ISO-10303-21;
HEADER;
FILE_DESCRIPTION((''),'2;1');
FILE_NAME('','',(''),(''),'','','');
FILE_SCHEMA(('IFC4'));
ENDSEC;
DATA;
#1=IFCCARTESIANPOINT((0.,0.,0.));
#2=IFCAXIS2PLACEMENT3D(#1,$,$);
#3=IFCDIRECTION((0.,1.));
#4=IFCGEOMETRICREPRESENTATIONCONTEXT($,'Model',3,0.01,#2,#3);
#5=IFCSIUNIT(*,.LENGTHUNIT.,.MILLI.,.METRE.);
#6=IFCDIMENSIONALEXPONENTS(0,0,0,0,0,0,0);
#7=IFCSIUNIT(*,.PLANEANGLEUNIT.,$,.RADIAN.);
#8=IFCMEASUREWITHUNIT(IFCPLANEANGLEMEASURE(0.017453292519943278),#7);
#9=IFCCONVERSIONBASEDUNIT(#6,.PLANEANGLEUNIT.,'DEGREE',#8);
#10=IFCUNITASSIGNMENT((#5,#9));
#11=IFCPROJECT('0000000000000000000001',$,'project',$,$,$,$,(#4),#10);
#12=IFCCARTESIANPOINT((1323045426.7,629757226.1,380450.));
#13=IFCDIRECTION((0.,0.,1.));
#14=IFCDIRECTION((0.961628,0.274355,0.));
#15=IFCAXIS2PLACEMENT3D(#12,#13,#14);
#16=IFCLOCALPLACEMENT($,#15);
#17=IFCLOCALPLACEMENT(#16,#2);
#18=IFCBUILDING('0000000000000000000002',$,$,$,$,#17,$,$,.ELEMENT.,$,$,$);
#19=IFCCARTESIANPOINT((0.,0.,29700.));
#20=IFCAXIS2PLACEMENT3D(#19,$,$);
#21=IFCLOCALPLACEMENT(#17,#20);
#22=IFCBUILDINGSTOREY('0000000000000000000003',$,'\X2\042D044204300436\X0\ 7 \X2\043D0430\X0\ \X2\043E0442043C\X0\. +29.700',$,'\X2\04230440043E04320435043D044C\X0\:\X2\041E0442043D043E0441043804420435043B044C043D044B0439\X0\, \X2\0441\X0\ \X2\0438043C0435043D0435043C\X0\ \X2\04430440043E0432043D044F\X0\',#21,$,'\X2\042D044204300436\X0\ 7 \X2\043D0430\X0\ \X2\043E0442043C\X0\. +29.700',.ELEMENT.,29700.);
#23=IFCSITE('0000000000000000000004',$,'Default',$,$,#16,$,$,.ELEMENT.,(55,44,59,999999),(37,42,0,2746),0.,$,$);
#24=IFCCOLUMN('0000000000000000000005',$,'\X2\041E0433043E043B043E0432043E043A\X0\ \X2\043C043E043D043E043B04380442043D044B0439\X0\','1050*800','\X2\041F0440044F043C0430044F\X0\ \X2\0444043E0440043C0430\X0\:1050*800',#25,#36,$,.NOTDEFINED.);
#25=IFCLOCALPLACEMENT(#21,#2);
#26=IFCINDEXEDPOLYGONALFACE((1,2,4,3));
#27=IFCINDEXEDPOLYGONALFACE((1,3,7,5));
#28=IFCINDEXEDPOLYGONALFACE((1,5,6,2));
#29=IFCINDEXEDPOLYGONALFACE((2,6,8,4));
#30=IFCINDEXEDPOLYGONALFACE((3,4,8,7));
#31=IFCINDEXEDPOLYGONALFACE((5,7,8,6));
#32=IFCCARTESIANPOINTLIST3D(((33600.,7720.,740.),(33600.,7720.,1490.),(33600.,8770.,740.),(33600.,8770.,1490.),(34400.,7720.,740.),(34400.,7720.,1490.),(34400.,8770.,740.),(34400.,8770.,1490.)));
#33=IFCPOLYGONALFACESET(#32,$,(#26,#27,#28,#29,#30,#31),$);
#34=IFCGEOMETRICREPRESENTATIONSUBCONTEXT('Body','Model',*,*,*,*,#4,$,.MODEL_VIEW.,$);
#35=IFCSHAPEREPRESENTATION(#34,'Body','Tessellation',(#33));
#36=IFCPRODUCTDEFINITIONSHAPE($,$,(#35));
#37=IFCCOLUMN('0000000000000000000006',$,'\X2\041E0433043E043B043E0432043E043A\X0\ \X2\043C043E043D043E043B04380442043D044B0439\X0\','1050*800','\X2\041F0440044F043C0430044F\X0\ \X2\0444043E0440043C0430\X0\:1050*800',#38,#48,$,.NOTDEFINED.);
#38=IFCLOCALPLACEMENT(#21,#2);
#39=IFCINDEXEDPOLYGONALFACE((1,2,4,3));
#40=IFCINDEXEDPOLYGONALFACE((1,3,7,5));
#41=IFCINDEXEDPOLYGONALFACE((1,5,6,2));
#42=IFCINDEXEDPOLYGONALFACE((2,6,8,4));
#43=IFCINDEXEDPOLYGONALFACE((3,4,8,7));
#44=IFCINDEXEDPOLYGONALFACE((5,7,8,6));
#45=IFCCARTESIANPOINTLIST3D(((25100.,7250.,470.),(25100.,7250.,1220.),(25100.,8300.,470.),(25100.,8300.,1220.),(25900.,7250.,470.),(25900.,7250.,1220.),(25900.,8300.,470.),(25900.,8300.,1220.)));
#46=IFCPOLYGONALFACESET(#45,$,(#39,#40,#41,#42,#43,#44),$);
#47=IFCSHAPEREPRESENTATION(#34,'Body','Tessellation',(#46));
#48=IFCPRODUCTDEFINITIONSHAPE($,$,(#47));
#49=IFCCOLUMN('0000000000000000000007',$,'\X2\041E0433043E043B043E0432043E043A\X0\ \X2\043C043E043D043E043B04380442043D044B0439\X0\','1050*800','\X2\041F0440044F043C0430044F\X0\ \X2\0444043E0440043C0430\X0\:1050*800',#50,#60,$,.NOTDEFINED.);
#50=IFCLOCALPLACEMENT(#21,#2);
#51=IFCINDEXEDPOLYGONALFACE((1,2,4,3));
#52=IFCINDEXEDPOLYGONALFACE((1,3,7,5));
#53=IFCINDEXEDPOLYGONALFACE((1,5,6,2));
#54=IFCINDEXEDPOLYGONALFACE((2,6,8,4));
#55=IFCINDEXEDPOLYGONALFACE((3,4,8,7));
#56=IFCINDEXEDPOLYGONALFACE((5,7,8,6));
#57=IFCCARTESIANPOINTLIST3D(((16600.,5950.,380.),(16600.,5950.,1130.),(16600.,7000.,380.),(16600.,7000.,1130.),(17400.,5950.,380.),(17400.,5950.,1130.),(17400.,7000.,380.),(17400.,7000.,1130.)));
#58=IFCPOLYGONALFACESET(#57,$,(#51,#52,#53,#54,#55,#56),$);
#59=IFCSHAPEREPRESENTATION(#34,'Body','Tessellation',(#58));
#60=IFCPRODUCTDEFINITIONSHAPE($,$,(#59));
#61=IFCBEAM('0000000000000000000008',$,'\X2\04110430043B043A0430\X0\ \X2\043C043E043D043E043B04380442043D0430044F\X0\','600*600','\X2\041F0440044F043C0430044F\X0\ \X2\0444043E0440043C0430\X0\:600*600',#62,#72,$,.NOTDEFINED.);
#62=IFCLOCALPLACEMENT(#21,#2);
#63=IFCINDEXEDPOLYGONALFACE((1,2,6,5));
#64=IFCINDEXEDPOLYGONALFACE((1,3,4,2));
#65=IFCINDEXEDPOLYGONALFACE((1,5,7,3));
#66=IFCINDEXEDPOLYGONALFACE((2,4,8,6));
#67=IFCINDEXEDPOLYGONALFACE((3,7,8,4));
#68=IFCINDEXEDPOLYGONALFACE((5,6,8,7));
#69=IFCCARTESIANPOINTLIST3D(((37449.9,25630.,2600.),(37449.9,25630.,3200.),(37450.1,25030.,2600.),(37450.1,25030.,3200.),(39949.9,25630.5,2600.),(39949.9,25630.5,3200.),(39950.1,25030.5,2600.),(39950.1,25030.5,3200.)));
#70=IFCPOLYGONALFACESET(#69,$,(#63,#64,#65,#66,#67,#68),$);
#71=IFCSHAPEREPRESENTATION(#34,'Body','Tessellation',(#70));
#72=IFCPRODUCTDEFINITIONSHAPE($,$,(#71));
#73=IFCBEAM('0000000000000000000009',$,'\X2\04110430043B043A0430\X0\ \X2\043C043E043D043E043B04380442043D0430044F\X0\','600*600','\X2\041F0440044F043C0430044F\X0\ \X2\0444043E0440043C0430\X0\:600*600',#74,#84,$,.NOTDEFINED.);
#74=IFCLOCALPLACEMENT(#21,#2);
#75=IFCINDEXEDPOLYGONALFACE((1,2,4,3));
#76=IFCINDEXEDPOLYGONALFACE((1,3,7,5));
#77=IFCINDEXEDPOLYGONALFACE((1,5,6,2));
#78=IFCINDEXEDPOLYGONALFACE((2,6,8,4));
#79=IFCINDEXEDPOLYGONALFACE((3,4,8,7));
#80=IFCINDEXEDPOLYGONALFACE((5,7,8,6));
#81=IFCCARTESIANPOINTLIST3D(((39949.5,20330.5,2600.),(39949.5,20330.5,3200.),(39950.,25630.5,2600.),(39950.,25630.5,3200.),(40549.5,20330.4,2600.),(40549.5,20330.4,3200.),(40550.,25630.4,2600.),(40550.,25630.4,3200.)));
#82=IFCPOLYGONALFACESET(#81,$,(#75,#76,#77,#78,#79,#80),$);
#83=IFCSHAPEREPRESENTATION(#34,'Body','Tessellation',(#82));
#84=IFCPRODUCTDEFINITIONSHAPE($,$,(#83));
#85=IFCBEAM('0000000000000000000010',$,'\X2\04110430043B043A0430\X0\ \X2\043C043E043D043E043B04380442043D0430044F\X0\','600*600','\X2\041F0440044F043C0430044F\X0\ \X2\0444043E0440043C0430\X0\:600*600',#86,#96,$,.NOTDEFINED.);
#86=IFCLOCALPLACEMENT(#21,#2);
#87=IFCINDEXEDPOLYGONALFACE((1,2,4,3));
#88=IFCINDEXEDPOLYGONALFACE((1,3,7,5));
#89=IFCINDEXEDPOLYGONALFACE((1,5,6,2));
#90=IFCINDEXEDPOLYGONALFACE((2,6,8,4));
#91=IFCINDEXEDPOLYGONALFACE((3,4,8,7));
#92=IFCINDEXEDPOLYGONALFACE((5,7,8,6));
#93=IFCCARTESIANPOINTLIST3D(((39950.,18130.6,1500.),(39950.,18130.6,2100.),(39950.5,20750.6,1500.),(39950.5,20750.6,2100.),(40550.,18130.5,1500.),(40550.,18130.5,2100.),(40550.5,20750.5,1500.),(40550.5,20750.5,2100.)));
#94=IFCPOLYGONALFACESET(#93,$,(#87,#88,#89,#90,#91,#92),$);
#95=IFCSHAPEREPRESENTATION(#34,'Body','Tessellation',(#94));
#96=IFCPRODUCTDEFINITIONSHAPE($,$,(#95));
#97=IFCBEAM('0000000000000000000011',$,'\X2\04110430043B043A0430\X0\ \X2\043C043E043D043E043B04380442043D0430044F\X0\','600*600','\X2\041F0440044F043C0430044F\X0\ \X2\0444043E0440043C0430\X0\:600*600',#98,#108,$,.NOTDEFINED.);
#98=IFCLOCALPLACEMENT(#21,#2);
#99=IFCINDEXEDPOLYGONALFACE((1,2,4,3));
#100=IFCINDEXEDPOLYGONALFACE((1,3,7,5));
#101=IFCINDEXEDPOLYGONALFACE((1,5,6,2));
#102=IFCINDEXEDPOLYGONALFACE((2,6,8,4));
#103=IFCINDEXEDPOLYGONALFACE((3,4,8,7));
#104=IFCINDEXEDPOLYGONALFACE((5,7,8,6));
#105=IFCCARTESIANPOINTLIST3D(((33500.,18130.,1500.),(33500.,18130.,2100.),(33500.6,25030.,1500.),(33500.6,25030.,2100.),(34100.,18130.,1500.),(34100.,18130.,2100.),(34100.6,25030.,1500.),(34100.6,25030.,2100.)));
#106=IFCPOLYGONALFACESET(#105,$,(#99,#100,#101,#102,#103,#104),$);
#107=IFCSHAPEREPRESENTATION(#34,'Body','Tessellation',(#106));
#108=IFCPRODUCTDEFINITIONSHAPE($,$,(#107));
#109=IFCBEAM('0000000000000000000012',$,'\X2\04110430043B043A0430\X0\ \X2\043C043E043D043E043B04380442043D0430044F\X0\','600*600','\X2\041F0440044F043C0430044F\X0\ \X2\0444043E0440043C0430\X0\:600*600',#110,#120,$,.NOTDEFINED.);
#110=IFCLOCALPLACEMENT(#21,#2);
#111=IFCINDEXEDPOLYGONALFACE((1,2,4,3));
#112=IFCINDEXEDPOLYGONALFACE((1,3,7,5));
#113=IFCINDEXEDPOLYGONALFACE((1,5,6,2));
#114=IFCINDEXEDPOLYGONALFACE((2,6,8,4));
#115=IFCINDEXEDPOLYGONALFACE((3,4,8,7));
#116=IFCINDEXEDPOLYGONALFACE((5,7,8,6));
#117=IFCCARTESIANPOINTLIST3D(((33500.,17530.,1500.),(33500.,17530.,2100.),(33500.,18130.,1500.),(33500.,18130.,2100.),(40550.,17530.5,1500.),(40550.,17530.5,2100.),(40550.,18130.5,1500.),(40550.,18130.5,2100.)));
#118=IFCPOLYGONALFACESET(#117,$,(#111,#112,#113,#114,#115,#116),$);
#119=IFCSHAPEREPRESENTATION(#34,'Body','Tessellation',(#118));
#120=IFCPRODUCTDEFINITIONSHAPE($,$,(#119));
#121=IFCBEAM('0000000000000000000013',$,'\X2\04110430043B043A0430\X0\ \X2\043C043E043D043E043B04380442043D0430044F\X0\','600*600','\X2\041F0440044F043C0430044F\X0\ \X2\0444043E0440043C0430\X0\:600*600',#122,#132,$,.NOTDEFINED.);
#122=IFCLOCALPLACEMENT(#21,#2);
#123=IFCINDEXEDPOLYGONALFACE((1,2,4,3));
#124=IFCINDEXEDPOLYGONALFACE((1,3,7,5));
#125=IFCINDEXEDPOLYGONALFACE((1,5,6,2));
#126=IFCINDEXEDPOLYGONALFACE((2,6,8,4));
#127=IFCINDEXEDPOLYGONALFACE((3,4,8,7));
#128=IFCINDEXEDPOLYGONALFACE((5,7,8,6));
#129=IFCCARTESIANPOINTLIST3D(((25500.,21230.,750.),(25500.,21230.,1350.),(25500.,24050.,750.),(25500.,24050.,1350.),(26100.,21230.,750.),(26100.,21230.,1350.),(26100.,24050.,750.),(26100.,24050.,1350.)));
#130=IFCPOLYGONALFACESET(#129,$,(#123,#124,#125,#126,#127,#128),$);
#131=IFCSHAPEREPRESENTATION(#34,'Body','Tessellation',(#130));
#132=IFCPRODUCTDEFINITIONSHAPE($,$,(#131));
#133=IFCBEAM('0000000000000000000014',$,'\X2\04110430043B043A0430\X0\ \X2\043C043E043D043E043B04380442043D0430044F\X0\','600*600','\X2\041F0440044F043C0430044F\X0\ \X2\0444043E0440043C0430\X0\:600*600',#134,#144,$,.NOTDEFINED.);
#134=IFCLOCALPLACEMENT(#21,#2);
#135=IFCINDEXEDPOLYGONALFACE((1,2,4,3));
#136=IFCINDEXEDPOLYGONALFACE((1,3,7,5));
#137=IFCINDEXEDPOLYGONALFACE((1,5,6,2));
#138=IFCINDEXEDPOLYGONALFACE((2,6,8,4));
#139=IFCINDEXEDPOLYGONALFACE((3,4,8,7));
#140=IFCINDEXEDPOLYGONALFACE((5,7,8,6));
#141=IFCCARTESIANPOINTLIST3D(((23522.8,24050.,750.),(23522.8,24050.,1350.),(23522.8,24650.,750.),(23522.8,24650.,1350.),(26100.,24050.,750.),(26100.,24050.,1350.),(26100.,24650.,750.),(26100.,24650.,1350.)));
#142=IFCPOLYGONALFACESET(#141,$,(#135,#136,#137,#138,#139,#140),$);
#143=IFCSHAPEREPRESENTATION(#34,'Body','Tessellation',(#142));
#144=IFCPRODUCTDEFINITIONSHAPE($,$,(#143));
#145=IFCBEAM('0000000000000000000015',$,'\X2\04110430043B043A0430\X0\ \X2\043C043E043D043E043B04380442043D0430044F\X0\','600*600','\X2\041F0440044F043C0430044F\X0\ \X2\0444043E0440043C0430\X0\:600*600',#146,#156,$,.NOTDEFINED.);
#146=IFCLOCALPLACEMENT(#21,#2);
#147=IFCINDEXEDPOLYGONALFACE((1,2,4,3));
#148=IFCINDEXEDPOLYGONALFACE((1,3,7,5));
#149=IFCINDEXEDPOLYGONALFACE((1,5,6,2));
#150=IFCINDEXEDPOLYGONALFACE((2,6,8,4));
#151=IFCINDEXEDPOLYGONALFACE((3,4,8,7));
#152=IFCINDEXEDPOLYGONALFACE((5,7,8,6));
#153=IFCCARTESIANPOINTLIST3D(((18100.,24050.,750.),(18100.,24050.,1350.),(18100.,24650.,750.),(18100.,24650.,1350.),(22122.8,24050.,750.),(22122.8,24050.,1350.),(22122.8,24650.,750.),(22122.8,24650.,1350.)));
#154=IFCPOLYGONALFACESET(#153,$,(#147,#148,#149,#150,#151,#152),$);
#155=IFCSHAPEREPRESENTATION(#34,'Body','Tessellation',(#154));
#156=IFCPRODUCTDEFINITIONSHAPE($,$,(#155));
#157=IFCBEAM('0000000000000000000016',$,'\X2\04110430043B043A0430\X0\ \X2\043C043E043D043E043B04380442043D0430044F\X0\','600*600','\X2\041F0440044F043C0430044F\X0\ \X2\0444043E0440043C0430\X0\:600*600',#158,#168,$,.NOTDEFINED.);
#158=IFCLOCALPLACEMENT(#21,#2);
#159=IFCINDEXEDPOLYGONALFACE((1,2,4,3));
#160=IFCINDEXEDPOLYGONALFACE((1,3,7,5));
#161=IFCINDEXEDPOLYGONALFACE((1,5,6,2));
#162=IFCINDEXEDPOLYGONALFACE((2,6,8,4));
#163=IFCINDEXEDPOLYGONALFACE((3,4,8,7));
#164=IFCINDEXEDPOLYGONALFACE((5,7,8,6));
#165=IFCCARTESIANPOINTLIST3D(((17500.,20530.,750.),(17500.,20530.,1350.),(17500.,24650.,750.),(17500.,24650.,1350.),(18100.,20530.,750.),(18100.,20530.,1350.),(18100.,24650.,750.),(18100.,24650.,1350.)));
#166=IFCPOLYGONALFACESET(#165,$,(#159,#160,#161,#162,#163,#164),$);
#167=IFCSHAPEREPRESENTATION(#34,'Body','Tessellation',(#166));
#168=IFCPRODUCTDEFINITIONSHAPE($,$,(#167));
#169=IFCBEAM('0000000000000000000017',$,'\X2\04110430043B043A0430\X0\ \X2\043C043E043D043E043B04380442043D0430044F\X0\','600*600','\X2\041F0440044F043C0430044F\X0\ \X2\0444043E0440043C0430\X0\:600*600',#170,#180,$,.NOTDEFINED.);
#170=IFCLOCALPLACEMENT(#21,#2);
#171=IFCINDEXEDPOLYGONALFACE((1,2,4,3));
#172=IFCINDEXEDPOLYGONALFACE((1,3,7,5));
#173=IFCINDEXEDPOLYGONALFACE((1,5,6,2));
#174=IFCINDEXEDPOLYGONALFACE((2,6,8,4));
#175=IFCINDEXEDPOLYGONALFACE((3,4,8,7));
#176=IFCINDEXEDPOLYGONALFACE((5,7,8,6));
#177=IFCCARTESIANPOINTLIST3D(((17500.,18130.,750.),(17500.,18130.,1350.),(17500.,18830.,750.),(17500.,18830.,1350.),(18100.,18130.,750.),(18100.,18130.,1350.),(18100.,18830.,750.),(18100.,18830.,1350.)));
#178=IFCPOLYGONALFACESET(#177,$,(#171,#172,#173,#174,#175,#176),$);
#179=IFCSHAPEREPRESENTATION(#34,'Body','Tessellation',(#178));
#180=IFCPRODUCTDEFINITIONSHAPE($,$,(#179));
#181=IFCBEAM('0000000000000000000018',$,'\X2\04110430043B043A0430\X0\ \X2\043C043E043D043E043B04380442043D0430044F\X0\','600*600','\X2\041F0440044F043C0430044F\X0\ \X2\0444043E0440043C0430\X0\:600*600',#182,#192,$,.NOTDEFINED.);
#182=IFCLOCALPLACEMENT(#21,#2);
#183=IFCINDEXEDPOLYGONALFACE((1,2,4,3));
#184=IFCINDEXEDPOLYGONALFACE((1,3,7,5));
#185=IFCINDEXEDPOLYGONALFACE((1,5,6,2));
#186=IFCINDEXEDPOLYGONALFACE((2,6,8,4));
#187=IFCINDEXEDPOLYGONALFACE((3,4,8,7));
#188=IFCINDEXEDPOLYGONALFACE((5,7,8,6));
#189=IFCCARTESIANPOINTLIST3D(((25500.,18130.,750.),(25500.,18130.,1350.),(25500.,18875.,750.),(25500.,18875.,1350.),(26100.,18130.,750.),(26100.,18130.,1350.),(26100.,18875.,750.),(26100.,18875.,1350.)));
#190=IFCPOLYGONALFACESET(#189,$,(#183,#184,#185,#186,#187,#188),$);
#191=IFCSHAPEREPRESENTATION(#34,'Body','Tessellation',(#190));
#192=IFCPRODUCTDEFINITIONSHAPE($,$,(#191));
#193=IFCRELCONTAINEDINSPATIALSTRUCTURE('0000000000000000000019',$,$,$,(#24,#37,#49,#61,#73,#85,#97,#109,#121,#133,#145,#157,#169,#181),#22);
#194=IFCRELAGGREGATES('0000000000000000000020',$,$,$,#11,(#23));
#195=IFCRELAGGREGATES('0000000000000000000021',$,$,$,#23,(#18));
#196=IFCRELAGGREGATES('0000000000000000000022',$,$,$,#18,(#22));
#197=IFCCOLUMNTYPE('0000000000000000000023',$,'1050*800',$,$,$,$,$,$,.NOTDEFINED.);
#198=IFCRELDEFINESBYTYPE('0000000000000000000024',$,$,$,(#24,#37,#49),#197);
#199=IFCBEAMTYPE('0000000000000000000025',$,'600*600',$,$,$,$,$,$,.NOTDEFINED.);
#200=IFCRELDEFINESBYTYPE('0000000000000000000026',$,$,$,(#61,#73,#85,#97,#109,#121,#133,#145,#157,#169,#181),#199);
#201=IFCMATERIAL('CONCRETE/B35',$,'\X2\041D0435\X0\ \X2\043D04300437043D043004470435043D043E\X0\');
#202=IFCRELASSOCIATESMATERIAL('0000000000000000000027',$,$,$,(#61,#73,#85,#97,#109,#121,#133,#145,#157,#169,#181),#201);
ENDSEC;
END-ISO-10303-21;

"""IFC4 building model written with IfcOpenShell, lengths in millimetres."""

from ifc_helpers import new_model, entity, si_unit, converted_unit, direction, frame, origin, place, context, subcontext, project, spatial, indexed_curve, outline, extrude, material, type_object, element, save


model = new_model("IFC4")

# Units and contexts
model_context = context("Model", 3, precision=0.01, world=origin(), true_north=direction((0.0, 1.0)))
body_context = subcontext(model_context, "Body", "Model", "MODEL_VIEW")
ifc_project = project(units=[si_unit("LENGTHUNIT", "METRE", prefix="MILLI"), converted_unit("PLANEANGLEUNIT", "DEGREE", entity("IfcPlaneAngleMeasure", 0.017453292519943278), si_unit("PLANEANGLEUNIT", "RADIAN"), dimensions=[0, 0, 0, 0, 0, 0, 0])], contexts=[model_context])

# Site, building, storey
site_placement = place(None, frame((1323045426.7, 629757226.1, 380450.0), z_axis=(0.0, 0.0, 1.0), x_axis=(0.961628, 0.274355, 0.0)))
site = spatial("IfcSite", under=ifc_project, at=site_placement, Name="Default", CompositionType="ELEMENT", RefLatitude=(55, 44, 59, 999999), RefLongitude=(37, 42, 0, 2746), RefElevation=0.0)
building_placement = place(site_placement, origin())
building = spatial("IfcBuilding", under=site, at=building_placement, CompositionType="ELEMENT")
storey_placement = place(building_placement, frame((0.0, 0.0, 29700.0)))
storey = spatial("IfcBuildingStorey", under=building, at=storey_placement, Name="Этаж 7 на отм. +29.700", ObjectType="Уровень:Относительный, с именем уровня", LongName="Этаж 7 на отм. +29.700", CompositionType="ELEMENT", Elevation=29700.0)

# Columns
column_type_1 = type_object("IfcColumnType", Name="1050*800", PredefinedType="NOTDEFINED")
column_1_placement = place(storey_placement, origin())
element("IfcColumn", 1, at=column_1_placement, inside=storey, type_object=column_type_1, Name="Оголовок монолитный", Description="1050*800", ObjectType="Прямая форма:1050*800", PredefinedType="NOTDEFINED", context=body_context, shape_type="SweptSolid", body=[
    extrude(outline(indexed_curve([(-525.0, -400.0), (525.0, -400.0), (525.0, 400.0), (-525.0, 400.0), (-525.0, -400.0)], self_intersect=False)), frame((34000.0, 8245.0, 740.0), z_axis=(0.0, 0.0, 1.0), x_axis=(0.0, 1.0, 0.0)), (0.0, 0.0, 1.0), 750.0),
])
column_2_placement = place(storey_placement, origin())
element("IfcColumn", 2, at=column_2_placement, inside=storey, type_object=column_type_1, Name="Оголовок монолитный", Description="1050*800", ObjectType="Прямая форма:1050*800", PredefinedType="NOTDEFINED", context=body_context, shape_type="SweptSolid", body=[
    extrude(outline(indexed_curve([(-525.0, -400.0), (525.0, -400.0), (525.0, 400.0), (-525.0, 400.0), (-525.0, -400.0)], self_intersect=False)), frame((25500.0, 7775.0, 470.0), z_axis=(0.0, 0.0, 1.0), x_axis=(0.0, 1.0, 0.0)), (0.0, 0.0, 1.0), 750.0),
])
column_3_placement = place(storey_placement, origin())
element("IfcColumn", 3, at=column_3_placement, inside=storey, type_object=column_type_1, Name="Оголовок монолитный", Description="1050*800", ObjectType="Прямая форма:1050*800", PredefinedType="NOTDEFINED", context=body_context, shape_type="SweptSolid", body=[
    extrude(outline(indexed_curve([(-525.0, -400.0), (525.0, -400.0), (525.0, 400.0), (-525.0, 400.0), (-525.0, -400.0)], self_intersect=False)), frame((17000.0, 6475.0, 380.0), z_axis=(0.0, 0.0, 1.0), x_axis=(0.0, 1.0, 0.0)), (0.0, 0.0, 1.0), 750.0),
])

# Beams
ifc_material_1 = material(Name="CONCRETE/B35", Category="Не назначено")
beam_type_1 = type_object("IfcBeamType", Name="600*600", PredefinedType="NOTDEFINED")
beam_1_placement = place(storey_placement, origin())
element("IfcBeam", 4, at=beam_1_placement, inside=storey, type_object=beam_type_1, material=ifc_material_1, Name="Балка монолитная", Description="600*600", ObjectType="Прямая форма:600*600", PredefinedType="NOTDEFINED", context=body_context, shape_type="SweptSolid", body=[
    extrude(outline(indexed_curve([(-300.0, -300.0), (300.0, -300.0), (300.0, 300.0), (-300.0, 300.0), (-300.0, -300.0)], self_intersect=False)), frame((37450.0, 25330.0, 2900.0), z_axis=(1.0, 0.00022, 0.0), x_axis=(-0.00022, 1.0, 0.0)), (0.0, 0.0, 1.0), 2500.0),
])
beam_2_placement = place(storey_placement, origin())
element("IfcBeam", 5, at=beam_2_placement, inside=storey, type_object=beam_type_1, material=ifc_material_1, Name="Балка монолитная", Description="600*600", ObjectType="Прямая форма:600*600", PredefinedType="NOTDEFINED", context=body_context, shape_type="SweptSolid", body=[
    extrude(outline(indexed_curve([(-2650.0, -300.0), (2650.0, -300.0), (2650.0, 300.0), (-2650.0, 300.0), (-2650.0, -300.0)], self_intersect=False)), frame((39949.7, 22980.5, 2900.0), z_axis=(1.0, -0.000102, 0.0), x_axis=(-0.000102, -1.0, 0.0)), (0.0, 0.0, 1.0), 600.0),
])
beam_3_placement = place(storey_placement, origin())
element("IfcBeam", 6, at=beam_3_placement, inside=storey, type_object=beam_type_1, material=ifc_material_1, Name="Балка монолитная", Description="600*600", ObjectType="Прямая форма:600*600", PredefinedType="NOTDEFINED", context=body_context, shape_type="SweptSolid", body=[
    extrude(outline(indexed_curve([(-1310.0, -300.0), (1310.0, -300.0), (1310.0, 300.0), (-1310.0, 300.0), (-1310.0, -300.0)], self_intersect=False)), frame((39950.2, 19440.6, 1800.0), z_axis=(1.0, -0.000207, 0.0), x_axis=(-0.000207, -1.0, 0.0)), (0.0, 0.0, 1.0), 600.0),
])
beam_4_placement = place(storey_placement, origin())
element("IfcBeam", 7, at=beam_4_placement, inside=storey, type_object=beam_type_1, material=ifc_material_1, Name="Балка монолитная", Description="600*600", ObjectType="Прямая форма:600*600", PredefinedType="NOTDEFINED", context=body_context, shape_type="SweptSolid", body=[
    extrude(outline(indexed_curve([(-3450.0, -300.0), (3450.0, -300.0), (3450.0, 300.0), (-3450.0, 300.0), (-3450.0, -300.0)], self_intersect=False)), frame((33500.3, 21580.0, 1800.0), z_axis=(1.0, -0.000078, 0.0), x_axis=(-0.000078, -1.0, 0.0)), (0.0, 0.0, 1.0), 600.0),
])
beam_5_placement = place(storey_placement, origin())
element("IfcBeam", 8, at=beam_5_placement, inside=storey, type_object=beam_type_1, material=ifc_material_1, Name="Балка монолитная", Description="600*600", ObjectType="Прямая форма:600*600", PredefinedType="NOTDEFINED", context=body_context, shape_type="SweptSolid", body=[
    extrude(outline(indexed_curve([(-300.0, -300.0), (300.0, -300.0), (300.0, 300.0), (-300.0, 300.0), (-300.0, -300.0)], self_intersect=False)), frame((33500.0, 17830.0, 1800.0), z_axis=(1.0, 0.000077, 0.0), x_axis=(-0.000077, 1.0, 0.0)), (0.0, 0.0, 1.0), 7050.0),
])
beam_6_placement = place(storey_placement, origin())
element("IfcBeam", 9, at=beam_6_placement, inside=storey, type_object=beam_type_1, material=ifc_material_1, Name="Балка монолитная", Description="600*600", ObjectType="Прямая форма:600*600", PredefinedType="NOTDEFINED", context=body_context, shape_type="SweptSolid", body=[
    extrude(outline(indexed_curve([(-1410.0, -300.0), (1410.0, -300.0), (1410.0, 300.0), (-1410.0, 300.0), (-1410.0, -300.0)], self_intersect=False)), frame((25500.0, 22640.0, 1050.0), z_axis=(1.0, 0.000001, 0.0), x_axis=(-0.000001, 1.0, 0.0)), (0.0, 0.0, 1.0), 600.0),
])
beam_7_placement = place(storey_placement, origin())
element("IfcBeam", 10, at=beam_7_placement, inside=storey, type_object=beam_type_1, material=ifc_material_1, Name="Балка монолитная", Description="600*600", ObjectType="Прямая форма:600*600", PredefinedType="NOTDEFINED", context=body_context, shape_type="SweptSolid", body=[
    extrude(outline(indexed_curve([(-300.0, -300.0), (300.0, -300.0), (300.0, 300.0), (-300.0, 300.0), (-300.0, -300.0)], self_intersect=False)), frame((23522.8, 24350.0, 1050.0), z_axis=(1.0, 0.0, 0.0), x_axis=(0.0, 1.0, 0.0)), (0.0, 0.0, 1.0), 2577.2),
])
beam_8_placement = place(storey_placement, origin())
element("IfcBeam", 11, at=beam_8_placement, inside=storey, type_object=beam_type_1, material=ifc_material_1, Name="Балка монолитная", Description="600*600", ObjectType="Прямая форма:600*600", PredefinedType="NOTDEFINED", context=body_context, shape_type="SweptSolid", body=[
    extrude(outline(indexed_curve([(-300.0, -300.0), (300.0, -300.0), (300.0, 300.0), (-300.0, 300.0), (-300.0, -300.0)], self_intersect=False)), frame((18100.0, 24350.0, 1050.0), z_axis=(1.0, 0.0, 0.0), x_axis=(0.0, 1.0, 0.0)), (0.0, 0.0, 1.0), 4022.8),
])
beam_9_placement = place(storey_placement, origin())
element("IfcBeam", 12, at=beam_9_placement, inside=storey, type_object=beam_type_1, material=ifc_material_1, Name="Балка монолитная", Description="600*600", ObjectType="Прямая форма:600*600", PredefinedType="NOTDEFINED", context=body_context, shape_type="SweptSolid", body=[
    extrude(outline(indexed_curve([(-2060.0, -300.0), (2060.0, -300.0), (2060.0, 300.0), (-2060.0, 300.0), (-2060.0, -300.0)], self_intersect=False)), frame((17500.0, 22590.0, 1050.0), z_axis=(1.0, 0.0, 0.0), x_axis=(0.0, -1.0, 0.0)), (0.0, 0.0, 1.0), 600.0),
])
beam_10_placement = place(storey_placement, origin())
element("IfcBeam", 13, at=beam_10_placement, inside=storey, type_object=beam_type_1, material=ifc_material_1, Name="Балка монолитная", Description="600*600", ObjectType="Прямая форма:600*600", PredefinedType="NOTDEFINED", context=body_context, shape_type="SweptSolid", body=[
    extrude(outline(indexed_curve([(-350.0, -300.0), (350.0, -300.0), (350.0, 300.0), (-350.0, 300.0), (-350.0, -300.0)], self_intersect=False)), frame((17500.0, 18480.0, 1050.0), z_axis=(1.0, 0.0, 0.0), x_axis=(0.0, -1.0, 0.0)), (0.0, 0.0, 1.0), 600.0),
])
beam_11_placement = place(storey_placement, origin())
element("IfcBeam", 14, at=beam_11_placement, inside=storey, type_object=beam_type_1, material=ifc_material_1, Name="Балка монолитная", Description="600*600", ObjectType="Прямая форма:600*600", PredefinedType="NOTDEFINED", context=body_context, shape_type="SweptSolid", body=[
    extrude(outline(indexed_curve([(-372.5, -300.0), (372.5, -300.0), (372.5, 300.0), (-372.5, 300.0), (-372.5, -300.0)], self_intersect=False)), frame((25500.0, 18502.5, 1050.0), z_axis=(1.0, 0.000001, 0.0), x_axis=(-0.000001, 1.0, 0.0)), (0.0, 0.0, 1.0), 600.0),
])

save(model, "model.ifc")
